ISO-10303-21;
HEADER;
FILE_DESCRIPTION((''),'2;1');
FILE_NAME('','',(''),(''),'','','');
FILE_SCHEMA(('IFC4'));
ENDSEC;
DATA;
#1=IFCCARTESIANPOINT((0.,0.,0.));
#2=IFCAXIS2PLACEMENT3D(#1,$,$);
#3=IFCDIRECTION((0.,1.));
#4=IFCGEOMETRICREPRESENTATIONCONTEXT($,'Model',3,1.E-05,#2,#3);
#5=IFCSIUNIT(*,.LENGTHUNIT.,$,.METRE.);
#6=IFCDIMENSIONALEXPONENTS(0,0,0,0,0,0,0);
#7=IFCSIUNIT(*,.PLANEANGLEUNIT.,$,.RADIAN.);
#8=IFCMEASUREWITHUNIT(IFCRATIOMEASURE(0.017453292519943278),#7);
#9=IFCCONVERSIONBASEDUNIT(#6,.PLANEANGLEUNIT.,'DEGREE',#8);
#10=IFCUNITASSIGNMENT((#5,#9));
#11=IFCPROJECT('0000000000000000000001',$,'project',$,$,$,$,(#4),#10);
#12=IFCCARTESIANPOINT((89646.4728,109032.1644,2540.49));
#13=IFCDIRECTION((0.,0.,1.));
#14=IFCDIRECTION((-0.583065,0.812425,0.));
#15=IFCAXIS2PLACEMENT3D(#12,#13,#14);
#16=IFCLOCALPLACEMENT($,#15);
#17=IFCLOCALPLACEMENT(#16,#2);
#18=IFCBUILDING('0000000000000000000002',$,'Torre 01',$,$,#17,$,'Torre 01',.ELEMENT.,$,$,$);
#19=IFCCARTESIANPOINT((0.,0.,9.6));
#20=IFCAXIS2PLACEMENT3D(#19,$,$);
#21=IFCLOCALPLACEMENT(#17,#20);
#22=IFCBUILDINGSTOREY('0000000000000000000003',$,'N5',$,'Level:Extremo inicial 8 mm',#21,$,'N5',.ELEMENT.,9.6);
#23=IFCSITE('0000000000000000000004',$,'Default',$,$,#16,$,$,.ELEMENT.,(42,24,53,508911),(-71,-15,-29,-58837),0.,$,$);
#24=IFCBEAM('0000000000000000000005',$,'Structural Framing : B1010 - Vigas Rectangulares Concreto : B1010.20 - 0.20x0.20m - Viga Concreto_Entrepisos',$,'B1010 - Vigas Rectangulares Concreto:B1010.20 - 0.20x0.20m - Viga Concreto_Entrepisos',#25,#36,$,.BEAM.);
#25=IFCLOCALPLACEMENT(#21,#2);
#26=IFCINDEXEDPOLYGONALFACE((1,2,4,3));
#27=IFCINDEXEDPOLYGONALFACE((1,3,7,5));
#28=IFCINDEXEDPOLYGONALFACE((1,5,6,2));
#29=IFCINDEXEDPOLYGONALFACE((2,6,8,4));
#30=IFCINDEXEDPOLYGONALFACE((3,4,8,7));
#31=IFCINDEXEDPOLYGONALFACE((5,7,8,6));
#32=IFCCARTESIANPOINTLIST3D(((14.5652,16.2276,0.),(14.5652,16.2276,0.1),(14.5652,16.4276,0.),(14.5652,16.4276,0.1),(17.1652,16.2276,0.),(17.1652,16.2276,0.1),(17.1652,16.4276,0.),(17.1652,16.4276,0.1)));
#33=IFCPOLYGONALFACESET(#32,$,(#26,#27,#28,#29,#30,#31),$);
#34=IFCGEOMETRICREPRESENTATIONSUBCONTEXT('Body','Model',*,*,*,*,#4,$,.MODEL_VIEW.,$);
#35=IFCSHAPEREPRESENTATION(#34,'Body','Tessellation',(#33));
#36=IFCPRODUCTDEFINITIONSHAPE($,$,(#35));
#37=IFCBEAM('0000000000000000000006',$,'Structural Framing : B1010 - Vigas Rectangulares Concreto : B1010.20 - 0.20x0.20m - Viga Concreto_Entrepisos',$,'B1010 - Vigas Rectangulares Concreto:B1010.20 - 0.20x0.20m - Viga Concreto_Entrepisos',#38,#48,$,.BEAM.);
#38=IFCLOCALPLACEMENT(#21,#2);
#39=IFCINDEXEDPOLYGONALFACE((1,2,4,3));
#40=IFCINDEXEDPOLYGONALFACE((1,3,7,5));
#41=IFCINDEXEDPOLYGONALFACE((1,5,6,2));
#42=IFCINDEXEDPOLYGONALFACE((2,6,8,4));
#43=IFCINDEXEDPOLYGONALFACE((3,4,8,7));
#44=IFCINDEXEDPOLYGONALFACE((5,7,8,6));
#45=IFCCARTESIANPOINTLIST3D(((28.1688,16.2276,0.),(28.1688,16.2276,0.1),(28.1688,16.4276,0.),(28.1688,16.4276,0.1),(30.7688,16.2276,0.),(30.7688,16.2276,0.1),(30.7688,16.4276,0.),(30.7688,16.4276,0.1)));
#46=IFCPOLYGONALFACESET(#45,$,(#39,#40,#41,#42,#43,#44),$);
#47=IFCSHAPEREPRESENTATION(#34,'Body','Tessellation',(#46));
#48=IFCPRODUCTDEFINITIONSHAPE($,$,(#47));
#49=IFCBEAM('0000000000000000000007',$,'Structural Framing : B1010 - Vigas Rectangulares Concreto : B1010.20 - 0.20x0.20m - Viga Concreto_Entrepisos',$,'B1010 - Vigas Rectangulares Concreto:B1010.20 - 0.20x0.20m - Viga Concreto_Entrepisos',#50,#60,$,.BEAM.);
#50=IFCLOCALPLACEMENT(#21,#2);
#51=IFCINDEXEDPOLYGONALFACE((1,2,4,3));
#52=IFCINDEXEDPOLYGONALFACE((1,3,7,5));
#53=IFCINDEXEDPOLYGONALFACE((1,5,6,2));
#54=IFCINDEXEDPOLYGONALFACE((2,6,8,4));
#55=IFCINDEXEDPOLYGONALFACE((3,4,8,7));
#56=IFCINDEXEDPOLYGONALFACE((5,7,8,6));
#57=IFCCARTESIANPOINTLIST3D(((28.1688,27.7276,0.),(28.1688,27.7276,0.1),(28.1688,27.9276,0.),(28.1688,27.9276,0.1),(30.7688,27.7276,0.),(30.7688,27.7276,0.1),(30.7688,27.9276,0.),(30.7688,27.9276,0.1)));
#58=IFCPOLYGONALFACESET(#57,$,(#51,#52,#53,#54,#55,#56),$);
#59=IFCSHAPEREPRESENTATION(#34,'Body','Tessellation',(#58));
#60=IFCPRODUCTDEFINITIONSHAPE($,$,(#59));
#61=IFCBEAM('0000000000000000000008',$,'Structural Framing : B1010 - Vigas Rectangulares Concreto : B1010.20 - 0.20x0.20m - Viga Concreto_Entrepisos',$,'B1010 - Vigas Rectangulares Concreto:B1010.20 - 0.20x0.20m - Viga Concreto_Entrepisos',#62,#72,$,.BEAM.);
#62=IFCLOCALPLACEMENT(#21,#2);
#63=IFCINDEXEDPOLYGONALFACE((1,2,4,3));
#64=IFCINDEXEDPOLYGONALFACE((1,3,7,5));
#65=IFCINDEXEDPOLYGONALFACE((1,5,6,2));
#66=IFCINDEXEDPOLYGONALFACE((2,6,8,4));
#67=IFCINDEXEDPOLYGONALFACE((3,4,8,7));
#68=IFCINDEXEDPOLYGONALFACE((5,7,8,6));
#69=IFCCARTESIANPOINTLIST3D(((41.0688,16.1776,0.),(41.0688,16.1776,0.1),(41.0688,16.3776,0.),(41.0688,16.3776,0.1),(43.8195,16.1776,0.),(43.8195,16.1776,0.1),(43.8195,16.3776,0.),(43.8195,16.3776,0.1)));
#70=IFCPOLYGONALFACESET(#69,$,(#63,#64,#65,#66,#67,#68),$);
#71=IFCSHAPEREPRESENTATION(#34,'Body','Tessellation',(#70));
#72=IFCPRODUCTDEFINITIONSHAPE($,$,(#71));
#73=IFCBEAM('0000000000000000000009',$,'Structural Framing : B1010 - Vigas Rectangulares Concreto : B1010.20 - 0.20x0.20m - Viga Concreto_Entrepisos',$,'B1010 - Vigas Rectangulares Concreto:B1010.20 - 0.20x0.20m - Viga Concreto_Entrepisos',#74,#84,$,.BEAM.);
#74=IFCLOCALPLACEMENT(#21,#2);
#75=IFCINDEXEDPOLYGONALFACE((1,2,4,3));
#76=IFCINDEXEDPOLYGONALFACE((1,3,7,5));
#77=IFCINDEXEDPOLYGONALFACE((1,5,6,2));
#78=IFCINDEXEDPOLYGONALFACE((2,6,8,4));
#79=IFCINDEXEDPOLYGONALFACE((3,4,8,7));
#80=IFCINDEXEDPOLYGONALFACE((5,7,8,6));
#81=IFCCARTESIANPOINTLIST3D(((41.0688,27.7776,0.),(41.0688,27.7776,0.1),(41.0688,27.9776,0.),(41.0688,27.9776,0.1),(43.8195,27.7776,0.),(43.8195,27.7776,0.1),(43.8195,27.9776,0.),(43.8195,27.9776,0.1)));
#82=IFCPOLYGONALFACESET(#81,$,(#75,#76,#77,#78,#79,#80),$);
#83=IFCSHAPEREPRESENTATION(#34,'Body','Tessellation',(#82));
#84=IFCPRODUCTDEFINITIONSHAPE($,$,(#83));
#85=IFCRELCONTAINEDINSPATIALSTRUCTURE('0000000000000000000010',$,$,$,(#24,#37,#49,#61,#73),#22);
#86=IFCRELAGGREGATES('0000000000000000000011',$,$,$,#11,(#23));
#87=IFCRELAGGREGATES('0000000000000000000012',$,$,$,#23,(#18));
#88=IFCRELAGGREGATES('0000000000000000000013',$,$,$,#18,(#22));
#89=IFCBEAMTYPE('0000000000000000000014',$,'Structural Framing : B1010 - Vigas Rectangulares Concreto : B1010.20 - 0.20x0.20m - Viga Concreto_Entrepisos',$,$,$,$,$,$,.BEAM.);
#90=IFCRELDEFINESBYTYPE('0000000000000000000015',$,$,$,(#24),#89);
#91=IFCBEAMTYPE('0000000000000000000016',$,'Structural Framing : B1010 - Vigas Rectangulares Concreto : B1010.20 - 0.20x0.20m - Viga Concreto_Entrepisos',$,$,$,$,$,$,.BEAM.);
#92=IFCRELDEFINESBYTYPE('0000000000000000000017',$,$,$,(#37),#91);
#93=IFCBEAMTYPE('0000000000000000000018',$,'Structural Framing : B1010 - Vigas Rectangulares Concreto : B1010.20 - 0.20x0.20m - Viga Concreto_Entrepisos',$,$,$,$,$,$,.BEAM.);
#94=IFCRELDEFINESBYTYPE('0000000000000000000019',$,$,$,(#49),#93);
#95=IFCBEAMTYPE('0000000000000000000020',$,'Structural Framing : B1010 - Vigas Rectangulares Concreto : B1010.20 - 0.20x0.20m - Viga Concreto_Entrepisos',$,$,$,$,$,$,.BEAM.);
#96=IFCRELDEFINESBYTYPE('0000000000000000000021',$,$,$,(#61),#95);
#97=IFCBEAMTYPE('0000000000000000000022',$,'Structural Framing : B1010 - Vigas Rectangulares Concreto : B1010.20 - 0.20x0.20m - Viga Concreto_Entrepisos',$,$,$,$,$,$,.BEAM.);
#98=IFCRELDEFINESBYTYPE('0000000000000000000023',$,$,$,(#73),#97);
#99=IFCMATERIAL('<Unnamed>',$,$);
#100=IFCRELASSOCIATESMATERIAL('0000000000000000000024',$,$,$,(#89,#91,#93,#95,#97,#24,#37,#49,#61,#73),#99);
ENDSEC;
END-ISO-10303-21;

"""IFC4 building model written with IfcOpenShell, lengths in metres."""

from ifc_helpers import new_model, entity, si_unit, converted_unit, direction, frame, frame_2d, origin, place, context, subcontext, project, spatial, polyline, segment, composite_curve, rectangle, outline, extrude, source, transform, mapped, material, material_profile, profile_set, profile_usage, type_object, type_shapes, element, save


model = new_model("IFC4")

# Units and contexts
model_context = context("Model", 3, precision=1e-05, world=origin(), true_north=direction((0.0, 1.0)))
body_context = subcontext(model_context, "Body", "Model", "MODEL_VIEW")
ifc_project = project(units=[si_unit("LENGTHUNIT", "METRE"), converted_unit("PLANEANGLEUNIT", "DEGREE", entity("IfcRatioMeasure", 0.017453292519943278), si_unit("PLANEANGLEUNIT", "RADIAN"), dimensions=[0, 0, 0, 0, 0, 0, 0])], contexts=[model_context])

# Site, building, storey
site_placement = place(None, frame((89646.4728, 109032.1644, 2540.49), z_axis=(0.0, 0.0, 1.0), x_axis=(-0.583065, 0.812425, 0.0)))
site = spatial("IfcSite", under=ifc_project, at=site_placement, Name="Default", CompositionType="ELEMENT", RefLatitude=(42, 24, 53, 508911), RefLongitude=(-71, -15, -29, -58837), RefElevation=0.0)
building_placement = place(site_placement, origin())
building = spatial("IfcBuilding", under=site, at=building_placement, Name="Torre 01", LongName="Torre 01", CompositionType="ELEMENT")
storey_placement = place(building_placement, frame((0.0, 0.0, 9.6)))
storey = spatial("IfcBuildingStorey", under=building, at=storey_placement, Name="N5", ObjectType="Level:Extremo inicial 8 mm", LongName="N5", CompositionType="ELEMENT", Elevation=9.6)

# Beams
ifc_material = material(Name="<Unnamed>")
ifc_material_profile_1 = material_profile(ifc_material, outline(composite_curve([segment(polyline([(-0.1, 0.0, 0.0), (-0.1, 0.1, 0.0)]), True, "CONTINUOUS"), segment(polyline([(-0.1, 0.1, 0.0), (0.1, 0.1, 0.0)]), True, "CONTINUOUS"), segment(polyline([(0.1, 0.1, 0.0), (0.1, 0.0, 0.0)]), True, "CONTINUOUS"), segment(polyline([(0.1, 0.0, 0.0), (-0.1, 0.0, 0.0)]), True, "CONTINUOUS")], self_intersect=False), kind="CURVE"), Name="B1010.20 - 0.20x0.20m - Viga Concreto_Entrepisos")
ifc_material_profile_2 = material_profile(ifc_material, outline(composite_curve([segment(polyline([(-1.3, -0.1, 0.1), (-1.3, 0.1, 0.1)]), True, "CONTINUOUS"), segment(polyline([(-1.3, 0.1, 0.1), (-1.3, 0.1, -0.1)]), True, "CONTINUOUS"), segment(polyline([(-1.3, 0.1, -0.1), (-1.3, -0.1, -0.1)]), True, "CONTINUOUS"), segment(polyline([(-1.3, -0.1, -0.1), (-1.3, -0.1, 0.1)]), True, "CONTINUOUS")], self_intersect=False), kind="CURVE"), Name="B1010.20 - 0.20x0.20m - Viga Concreto_Entrepisos")
ifc_profile_set_1 = profile_set([ifc_material_profile_1, ifc_material_profile_2], Name="B1010.20 - 0.20x0.20m - Viga Concreto_Entrepisos")
ifc_profile_usage_1 = profile_usage(ifc_profile_set_1, cardinal=8)
beam_type_1 = type_object("IfcBeamType", Name="Structural Framing : B1010 - Vigas Rectangulares Concreto : B1010.20 - 0.20x0.20m - Viga Concreto_Entrepisos", PredefinedType="BEAM", material=ifc_profile_set_1)
shared_shape_1 = source(origin(), body_context, "Body", "SweptSolid", [
    extrude(rectangle(XDim=0.1, YDim=0.2, at=frame_2d((0.0, 0.0), x_axis=(1.0, 0.0))), frame((17.1652, 16.3276, 9.65), z_axis=(-1.0, 0.0, 0.0), x_axis=(0.0, 0.0, -1.0)), (0.0, 0.0, 1.0), 2.6),
])
type_shapes(beam_type_1, [shared_shape_1])
beam_1_placement = place(storey_placement, frame((0.0, 0.0, -9.6)))
element("IfcBeam", 1, at=beam_1_placement, inside=storey, type_object=beam_type_1, material=ifc_profile_usage_1, Name="Structural Framing : B1010 - Vigas Rectangulares Concreto : B1010.20 - 0.20x0.20m - Viga Concreto_Entrepisos", ObjectType="B1010 - Vigas Rectangulares Concreto:B1010.20 - 0.20x0.20m - Viga Concreto_Entrepisos", PredefinedType="BEAM", context=body_context, shape_type="MappedRepresentation", body=[
    mapped(shared_shape_1, transform((0.0, 0.0, 0.0), scale=1.0)),
])
ifc_profile_usage_2 = profile_usage(ifc_profile_set_1, cardinal=8)
beam_type_2 = type_object("IfcBeamType", Name="Structural Framing : B1010 - Vigas Rectangulares Concreto : B1010.20 - 0.20x0.20m - Viga Concreto_Entrepisos", PredefinedType="BEAM", material=ifc_profile_set_1)
shared_shape_2 = source(origin(), body_context, "Body", "SweptSolid", [
    extrude(rectangle(XDim=0.1, YDim=0.2, at=frame_2d((0.0, 0.0), x_axis=(1.0, 0.0))), frame((28.1688, 16.3276, 9.65), z_axis=(1.0, 0.0, 0.0), x_axis=(0.0, 0.0, -1.0)), (0.0, 0.0, 1.0), 2.6),
])
type_shapes(beam_type_2, [shared_shape_2])
beam_2_placement = place(storey_placement, frame((0.0, 0.0, -9.6)))
element("IfcBeam", 2, at=beam_2_placement, inside=storey, type_object=beam_type_2, material=ifc_profile_usage_2, Name="Structural Framing : B1010 - Vigas Rectangulares Concreto : B1010.20 - 0.20x0.20m - Viga Concreto_Entrepisos", ObjectType="B1010 - Vigas Rectangulares Concreto:B1010.20 - 0.20x0.20m - Viga Concreto_Entrepisos", PredefinedType="BEAM", context=body_context, shape_type="MappedRepresentation", body=[
    mapped(shared_shape_2, transform((0.0, 0.0, 0.0), scale=1.0)),
])
ifc_profile_usage_3 = profile_usage(ifc_profile_set_1, cardinal=8)
beam_type_3 = type_object("IfcBeamType", Name="Structural Framing : B1010 - Vigas Rectangulares Concreto : B1010.20 - 0.20x0.20m - Viga Concreto_Entrepisos", PredefinedType="BEAM", material=ifc_profile_set_1)
shared_shape_3 = source(origin(), body_context, "Body", "SweptSolid", [
    extrude(rectangle(XDim=0.1, YDim=0.2, at=frame_2d((0.0, 0.0), x_axis=(1.0, 0.0))), frame((28.1688, 27.8276, 9.65), z_axis=(1.0, 0.0, 0.0), x_axis=(0.0, 0.0, -1.0)), (0.0, 0.0, 1.0), 2.6),
])
type_shapes(beam_type_3, [shared_shape_3])
beam_3_placement = place(storey_placement, frame((0.0, 0.0, -9.6)))
element("IfcBeam", 3, at=beam_3_placement, inside=storey, type_object=beam_type_3, material=ifc_profile_usage_3, Name="Structural Framing : B1010 - Vigas Rectangulares Concreto : B1010.20 - 0.20x0.20m - Viga Concreto_Entrepisos", ObjectType="B1010 - Vigas Rectangulares Concreto:B1010.20 - 0.20x0.20m - Viga Concreto_Entrepisos", PredefinedType="BEAM", context=body_context, shape_type="MappedRepresentation", body=[
    mapped(shared_shape_3, transform((0.0, 0.0, 0.0), scale=1.0)),
])
ifc_profile_usage_4 = profile_usage(ifc_profile_set_1, cardinal=8)
beam_type_4 = type_object("IfcBeamType", Name="Structural Framing : B1010 - Vigas Rectangulares Concreto : B1010.20 - 0.20x0.20m - Viga Concreto_Entrepisos", PredefinedType="BEAM", material=ifc_profile_set_1)
shared_shape_4 = source(origin(), body_context, "Body", "SweptSolid", [
    extrude(rectangle(XDim=0.1, YDim=0.2, at=frame_2d((0.0, 0.0), x_axis=(1.0, 0.0))), frame((43.8195, 16.2776, 9.65), z_axis=(-1.0, 0.0, 0.0), x_axis=(0.0, 0.0, -1.0)), (0.0, 0.0, 1.0), 2.7507),
])
type_shapes(beam_type_4, [shared_shape_4])
beam_4_placement = place(storey_placement, frame((0.0, 0.0, -9.6)))
element("IfcBeam", 4, at=beam_4_placement, inside=storey, type_object=beam_type_4, material=ifc_profile_usage_4, Name="Structural Framing : B1010 - Vigas Rectangulares Concreto : B1010.20 - 0.20x0.20m - Viga Concreto_Entrepisos", ObjectType="B1010 - Vigas Rectangulares Concreto:B1010.20 - 0.20x0.20m - Viga Concreto_Entrepisos", PredefinedType="BEAM", context=body_context, shape_type="MappedRepresentation", body=[
    mapped(shared_shape_4, transform((0.0, 0.0, 0.0), scale=1.0)),
])
ifc_profile_usage_5 = profile_usage(ifc_profile_set_1, cardinal=8)
beam_type_5 = type_object("IfcBeamType", Name="Structural Framing : B1010 - Vigas Rectangulares Concreto : B1010.20 - 0.20x0.20m - Viga Concreto_Entrepisos", PredefinedType="BEAM", material=ifc_profile_set_1)
shared_shape_5 = source(origin(), body_context, "Body", "SweptSolid", [
    extrude(rectangle(XDim=0.1, YDim=0.2, at=frame_2d((0.0, 0.0), x_axis=(1.0, 0.0))), frame((43.8195, 27.8776, 9.65), z_axis=(-1.0, 0.0, 0.0), x_axis=(0.0, 0.0, -1.0)), (0.0, 0.0, 1.0), 2.7507),
])
type_shapes(beam_type_5, [shared_shape_5])
beam_5_placement = place(storey_placement, frame((0.0, 0.0, -9.6)))
element("IfcBeam", 5, at=beam_5_placement, inside=storey, type_object=beam_type_5, material=ifc_profile_usage_5, Name="Structural Framing : B1010 - Vigas Rectangulares Concreto : B1010.20 - 0.20x0.20m - Viga Concreto_Entrepisos", ObjectType="B1010 - Vigas Rectangulares Concreto:B1010.20 - 0.20x0.20m - Viga Concreto_Entrepisos", PredefinedType="BEAM", context=body_context, shape_type="MappedRepresentation", body=[
    mapped(shared_shape_5, transform((0.0, 0.0, 0.0), scale=1.0)),
])

save(model, "model.ifc")
